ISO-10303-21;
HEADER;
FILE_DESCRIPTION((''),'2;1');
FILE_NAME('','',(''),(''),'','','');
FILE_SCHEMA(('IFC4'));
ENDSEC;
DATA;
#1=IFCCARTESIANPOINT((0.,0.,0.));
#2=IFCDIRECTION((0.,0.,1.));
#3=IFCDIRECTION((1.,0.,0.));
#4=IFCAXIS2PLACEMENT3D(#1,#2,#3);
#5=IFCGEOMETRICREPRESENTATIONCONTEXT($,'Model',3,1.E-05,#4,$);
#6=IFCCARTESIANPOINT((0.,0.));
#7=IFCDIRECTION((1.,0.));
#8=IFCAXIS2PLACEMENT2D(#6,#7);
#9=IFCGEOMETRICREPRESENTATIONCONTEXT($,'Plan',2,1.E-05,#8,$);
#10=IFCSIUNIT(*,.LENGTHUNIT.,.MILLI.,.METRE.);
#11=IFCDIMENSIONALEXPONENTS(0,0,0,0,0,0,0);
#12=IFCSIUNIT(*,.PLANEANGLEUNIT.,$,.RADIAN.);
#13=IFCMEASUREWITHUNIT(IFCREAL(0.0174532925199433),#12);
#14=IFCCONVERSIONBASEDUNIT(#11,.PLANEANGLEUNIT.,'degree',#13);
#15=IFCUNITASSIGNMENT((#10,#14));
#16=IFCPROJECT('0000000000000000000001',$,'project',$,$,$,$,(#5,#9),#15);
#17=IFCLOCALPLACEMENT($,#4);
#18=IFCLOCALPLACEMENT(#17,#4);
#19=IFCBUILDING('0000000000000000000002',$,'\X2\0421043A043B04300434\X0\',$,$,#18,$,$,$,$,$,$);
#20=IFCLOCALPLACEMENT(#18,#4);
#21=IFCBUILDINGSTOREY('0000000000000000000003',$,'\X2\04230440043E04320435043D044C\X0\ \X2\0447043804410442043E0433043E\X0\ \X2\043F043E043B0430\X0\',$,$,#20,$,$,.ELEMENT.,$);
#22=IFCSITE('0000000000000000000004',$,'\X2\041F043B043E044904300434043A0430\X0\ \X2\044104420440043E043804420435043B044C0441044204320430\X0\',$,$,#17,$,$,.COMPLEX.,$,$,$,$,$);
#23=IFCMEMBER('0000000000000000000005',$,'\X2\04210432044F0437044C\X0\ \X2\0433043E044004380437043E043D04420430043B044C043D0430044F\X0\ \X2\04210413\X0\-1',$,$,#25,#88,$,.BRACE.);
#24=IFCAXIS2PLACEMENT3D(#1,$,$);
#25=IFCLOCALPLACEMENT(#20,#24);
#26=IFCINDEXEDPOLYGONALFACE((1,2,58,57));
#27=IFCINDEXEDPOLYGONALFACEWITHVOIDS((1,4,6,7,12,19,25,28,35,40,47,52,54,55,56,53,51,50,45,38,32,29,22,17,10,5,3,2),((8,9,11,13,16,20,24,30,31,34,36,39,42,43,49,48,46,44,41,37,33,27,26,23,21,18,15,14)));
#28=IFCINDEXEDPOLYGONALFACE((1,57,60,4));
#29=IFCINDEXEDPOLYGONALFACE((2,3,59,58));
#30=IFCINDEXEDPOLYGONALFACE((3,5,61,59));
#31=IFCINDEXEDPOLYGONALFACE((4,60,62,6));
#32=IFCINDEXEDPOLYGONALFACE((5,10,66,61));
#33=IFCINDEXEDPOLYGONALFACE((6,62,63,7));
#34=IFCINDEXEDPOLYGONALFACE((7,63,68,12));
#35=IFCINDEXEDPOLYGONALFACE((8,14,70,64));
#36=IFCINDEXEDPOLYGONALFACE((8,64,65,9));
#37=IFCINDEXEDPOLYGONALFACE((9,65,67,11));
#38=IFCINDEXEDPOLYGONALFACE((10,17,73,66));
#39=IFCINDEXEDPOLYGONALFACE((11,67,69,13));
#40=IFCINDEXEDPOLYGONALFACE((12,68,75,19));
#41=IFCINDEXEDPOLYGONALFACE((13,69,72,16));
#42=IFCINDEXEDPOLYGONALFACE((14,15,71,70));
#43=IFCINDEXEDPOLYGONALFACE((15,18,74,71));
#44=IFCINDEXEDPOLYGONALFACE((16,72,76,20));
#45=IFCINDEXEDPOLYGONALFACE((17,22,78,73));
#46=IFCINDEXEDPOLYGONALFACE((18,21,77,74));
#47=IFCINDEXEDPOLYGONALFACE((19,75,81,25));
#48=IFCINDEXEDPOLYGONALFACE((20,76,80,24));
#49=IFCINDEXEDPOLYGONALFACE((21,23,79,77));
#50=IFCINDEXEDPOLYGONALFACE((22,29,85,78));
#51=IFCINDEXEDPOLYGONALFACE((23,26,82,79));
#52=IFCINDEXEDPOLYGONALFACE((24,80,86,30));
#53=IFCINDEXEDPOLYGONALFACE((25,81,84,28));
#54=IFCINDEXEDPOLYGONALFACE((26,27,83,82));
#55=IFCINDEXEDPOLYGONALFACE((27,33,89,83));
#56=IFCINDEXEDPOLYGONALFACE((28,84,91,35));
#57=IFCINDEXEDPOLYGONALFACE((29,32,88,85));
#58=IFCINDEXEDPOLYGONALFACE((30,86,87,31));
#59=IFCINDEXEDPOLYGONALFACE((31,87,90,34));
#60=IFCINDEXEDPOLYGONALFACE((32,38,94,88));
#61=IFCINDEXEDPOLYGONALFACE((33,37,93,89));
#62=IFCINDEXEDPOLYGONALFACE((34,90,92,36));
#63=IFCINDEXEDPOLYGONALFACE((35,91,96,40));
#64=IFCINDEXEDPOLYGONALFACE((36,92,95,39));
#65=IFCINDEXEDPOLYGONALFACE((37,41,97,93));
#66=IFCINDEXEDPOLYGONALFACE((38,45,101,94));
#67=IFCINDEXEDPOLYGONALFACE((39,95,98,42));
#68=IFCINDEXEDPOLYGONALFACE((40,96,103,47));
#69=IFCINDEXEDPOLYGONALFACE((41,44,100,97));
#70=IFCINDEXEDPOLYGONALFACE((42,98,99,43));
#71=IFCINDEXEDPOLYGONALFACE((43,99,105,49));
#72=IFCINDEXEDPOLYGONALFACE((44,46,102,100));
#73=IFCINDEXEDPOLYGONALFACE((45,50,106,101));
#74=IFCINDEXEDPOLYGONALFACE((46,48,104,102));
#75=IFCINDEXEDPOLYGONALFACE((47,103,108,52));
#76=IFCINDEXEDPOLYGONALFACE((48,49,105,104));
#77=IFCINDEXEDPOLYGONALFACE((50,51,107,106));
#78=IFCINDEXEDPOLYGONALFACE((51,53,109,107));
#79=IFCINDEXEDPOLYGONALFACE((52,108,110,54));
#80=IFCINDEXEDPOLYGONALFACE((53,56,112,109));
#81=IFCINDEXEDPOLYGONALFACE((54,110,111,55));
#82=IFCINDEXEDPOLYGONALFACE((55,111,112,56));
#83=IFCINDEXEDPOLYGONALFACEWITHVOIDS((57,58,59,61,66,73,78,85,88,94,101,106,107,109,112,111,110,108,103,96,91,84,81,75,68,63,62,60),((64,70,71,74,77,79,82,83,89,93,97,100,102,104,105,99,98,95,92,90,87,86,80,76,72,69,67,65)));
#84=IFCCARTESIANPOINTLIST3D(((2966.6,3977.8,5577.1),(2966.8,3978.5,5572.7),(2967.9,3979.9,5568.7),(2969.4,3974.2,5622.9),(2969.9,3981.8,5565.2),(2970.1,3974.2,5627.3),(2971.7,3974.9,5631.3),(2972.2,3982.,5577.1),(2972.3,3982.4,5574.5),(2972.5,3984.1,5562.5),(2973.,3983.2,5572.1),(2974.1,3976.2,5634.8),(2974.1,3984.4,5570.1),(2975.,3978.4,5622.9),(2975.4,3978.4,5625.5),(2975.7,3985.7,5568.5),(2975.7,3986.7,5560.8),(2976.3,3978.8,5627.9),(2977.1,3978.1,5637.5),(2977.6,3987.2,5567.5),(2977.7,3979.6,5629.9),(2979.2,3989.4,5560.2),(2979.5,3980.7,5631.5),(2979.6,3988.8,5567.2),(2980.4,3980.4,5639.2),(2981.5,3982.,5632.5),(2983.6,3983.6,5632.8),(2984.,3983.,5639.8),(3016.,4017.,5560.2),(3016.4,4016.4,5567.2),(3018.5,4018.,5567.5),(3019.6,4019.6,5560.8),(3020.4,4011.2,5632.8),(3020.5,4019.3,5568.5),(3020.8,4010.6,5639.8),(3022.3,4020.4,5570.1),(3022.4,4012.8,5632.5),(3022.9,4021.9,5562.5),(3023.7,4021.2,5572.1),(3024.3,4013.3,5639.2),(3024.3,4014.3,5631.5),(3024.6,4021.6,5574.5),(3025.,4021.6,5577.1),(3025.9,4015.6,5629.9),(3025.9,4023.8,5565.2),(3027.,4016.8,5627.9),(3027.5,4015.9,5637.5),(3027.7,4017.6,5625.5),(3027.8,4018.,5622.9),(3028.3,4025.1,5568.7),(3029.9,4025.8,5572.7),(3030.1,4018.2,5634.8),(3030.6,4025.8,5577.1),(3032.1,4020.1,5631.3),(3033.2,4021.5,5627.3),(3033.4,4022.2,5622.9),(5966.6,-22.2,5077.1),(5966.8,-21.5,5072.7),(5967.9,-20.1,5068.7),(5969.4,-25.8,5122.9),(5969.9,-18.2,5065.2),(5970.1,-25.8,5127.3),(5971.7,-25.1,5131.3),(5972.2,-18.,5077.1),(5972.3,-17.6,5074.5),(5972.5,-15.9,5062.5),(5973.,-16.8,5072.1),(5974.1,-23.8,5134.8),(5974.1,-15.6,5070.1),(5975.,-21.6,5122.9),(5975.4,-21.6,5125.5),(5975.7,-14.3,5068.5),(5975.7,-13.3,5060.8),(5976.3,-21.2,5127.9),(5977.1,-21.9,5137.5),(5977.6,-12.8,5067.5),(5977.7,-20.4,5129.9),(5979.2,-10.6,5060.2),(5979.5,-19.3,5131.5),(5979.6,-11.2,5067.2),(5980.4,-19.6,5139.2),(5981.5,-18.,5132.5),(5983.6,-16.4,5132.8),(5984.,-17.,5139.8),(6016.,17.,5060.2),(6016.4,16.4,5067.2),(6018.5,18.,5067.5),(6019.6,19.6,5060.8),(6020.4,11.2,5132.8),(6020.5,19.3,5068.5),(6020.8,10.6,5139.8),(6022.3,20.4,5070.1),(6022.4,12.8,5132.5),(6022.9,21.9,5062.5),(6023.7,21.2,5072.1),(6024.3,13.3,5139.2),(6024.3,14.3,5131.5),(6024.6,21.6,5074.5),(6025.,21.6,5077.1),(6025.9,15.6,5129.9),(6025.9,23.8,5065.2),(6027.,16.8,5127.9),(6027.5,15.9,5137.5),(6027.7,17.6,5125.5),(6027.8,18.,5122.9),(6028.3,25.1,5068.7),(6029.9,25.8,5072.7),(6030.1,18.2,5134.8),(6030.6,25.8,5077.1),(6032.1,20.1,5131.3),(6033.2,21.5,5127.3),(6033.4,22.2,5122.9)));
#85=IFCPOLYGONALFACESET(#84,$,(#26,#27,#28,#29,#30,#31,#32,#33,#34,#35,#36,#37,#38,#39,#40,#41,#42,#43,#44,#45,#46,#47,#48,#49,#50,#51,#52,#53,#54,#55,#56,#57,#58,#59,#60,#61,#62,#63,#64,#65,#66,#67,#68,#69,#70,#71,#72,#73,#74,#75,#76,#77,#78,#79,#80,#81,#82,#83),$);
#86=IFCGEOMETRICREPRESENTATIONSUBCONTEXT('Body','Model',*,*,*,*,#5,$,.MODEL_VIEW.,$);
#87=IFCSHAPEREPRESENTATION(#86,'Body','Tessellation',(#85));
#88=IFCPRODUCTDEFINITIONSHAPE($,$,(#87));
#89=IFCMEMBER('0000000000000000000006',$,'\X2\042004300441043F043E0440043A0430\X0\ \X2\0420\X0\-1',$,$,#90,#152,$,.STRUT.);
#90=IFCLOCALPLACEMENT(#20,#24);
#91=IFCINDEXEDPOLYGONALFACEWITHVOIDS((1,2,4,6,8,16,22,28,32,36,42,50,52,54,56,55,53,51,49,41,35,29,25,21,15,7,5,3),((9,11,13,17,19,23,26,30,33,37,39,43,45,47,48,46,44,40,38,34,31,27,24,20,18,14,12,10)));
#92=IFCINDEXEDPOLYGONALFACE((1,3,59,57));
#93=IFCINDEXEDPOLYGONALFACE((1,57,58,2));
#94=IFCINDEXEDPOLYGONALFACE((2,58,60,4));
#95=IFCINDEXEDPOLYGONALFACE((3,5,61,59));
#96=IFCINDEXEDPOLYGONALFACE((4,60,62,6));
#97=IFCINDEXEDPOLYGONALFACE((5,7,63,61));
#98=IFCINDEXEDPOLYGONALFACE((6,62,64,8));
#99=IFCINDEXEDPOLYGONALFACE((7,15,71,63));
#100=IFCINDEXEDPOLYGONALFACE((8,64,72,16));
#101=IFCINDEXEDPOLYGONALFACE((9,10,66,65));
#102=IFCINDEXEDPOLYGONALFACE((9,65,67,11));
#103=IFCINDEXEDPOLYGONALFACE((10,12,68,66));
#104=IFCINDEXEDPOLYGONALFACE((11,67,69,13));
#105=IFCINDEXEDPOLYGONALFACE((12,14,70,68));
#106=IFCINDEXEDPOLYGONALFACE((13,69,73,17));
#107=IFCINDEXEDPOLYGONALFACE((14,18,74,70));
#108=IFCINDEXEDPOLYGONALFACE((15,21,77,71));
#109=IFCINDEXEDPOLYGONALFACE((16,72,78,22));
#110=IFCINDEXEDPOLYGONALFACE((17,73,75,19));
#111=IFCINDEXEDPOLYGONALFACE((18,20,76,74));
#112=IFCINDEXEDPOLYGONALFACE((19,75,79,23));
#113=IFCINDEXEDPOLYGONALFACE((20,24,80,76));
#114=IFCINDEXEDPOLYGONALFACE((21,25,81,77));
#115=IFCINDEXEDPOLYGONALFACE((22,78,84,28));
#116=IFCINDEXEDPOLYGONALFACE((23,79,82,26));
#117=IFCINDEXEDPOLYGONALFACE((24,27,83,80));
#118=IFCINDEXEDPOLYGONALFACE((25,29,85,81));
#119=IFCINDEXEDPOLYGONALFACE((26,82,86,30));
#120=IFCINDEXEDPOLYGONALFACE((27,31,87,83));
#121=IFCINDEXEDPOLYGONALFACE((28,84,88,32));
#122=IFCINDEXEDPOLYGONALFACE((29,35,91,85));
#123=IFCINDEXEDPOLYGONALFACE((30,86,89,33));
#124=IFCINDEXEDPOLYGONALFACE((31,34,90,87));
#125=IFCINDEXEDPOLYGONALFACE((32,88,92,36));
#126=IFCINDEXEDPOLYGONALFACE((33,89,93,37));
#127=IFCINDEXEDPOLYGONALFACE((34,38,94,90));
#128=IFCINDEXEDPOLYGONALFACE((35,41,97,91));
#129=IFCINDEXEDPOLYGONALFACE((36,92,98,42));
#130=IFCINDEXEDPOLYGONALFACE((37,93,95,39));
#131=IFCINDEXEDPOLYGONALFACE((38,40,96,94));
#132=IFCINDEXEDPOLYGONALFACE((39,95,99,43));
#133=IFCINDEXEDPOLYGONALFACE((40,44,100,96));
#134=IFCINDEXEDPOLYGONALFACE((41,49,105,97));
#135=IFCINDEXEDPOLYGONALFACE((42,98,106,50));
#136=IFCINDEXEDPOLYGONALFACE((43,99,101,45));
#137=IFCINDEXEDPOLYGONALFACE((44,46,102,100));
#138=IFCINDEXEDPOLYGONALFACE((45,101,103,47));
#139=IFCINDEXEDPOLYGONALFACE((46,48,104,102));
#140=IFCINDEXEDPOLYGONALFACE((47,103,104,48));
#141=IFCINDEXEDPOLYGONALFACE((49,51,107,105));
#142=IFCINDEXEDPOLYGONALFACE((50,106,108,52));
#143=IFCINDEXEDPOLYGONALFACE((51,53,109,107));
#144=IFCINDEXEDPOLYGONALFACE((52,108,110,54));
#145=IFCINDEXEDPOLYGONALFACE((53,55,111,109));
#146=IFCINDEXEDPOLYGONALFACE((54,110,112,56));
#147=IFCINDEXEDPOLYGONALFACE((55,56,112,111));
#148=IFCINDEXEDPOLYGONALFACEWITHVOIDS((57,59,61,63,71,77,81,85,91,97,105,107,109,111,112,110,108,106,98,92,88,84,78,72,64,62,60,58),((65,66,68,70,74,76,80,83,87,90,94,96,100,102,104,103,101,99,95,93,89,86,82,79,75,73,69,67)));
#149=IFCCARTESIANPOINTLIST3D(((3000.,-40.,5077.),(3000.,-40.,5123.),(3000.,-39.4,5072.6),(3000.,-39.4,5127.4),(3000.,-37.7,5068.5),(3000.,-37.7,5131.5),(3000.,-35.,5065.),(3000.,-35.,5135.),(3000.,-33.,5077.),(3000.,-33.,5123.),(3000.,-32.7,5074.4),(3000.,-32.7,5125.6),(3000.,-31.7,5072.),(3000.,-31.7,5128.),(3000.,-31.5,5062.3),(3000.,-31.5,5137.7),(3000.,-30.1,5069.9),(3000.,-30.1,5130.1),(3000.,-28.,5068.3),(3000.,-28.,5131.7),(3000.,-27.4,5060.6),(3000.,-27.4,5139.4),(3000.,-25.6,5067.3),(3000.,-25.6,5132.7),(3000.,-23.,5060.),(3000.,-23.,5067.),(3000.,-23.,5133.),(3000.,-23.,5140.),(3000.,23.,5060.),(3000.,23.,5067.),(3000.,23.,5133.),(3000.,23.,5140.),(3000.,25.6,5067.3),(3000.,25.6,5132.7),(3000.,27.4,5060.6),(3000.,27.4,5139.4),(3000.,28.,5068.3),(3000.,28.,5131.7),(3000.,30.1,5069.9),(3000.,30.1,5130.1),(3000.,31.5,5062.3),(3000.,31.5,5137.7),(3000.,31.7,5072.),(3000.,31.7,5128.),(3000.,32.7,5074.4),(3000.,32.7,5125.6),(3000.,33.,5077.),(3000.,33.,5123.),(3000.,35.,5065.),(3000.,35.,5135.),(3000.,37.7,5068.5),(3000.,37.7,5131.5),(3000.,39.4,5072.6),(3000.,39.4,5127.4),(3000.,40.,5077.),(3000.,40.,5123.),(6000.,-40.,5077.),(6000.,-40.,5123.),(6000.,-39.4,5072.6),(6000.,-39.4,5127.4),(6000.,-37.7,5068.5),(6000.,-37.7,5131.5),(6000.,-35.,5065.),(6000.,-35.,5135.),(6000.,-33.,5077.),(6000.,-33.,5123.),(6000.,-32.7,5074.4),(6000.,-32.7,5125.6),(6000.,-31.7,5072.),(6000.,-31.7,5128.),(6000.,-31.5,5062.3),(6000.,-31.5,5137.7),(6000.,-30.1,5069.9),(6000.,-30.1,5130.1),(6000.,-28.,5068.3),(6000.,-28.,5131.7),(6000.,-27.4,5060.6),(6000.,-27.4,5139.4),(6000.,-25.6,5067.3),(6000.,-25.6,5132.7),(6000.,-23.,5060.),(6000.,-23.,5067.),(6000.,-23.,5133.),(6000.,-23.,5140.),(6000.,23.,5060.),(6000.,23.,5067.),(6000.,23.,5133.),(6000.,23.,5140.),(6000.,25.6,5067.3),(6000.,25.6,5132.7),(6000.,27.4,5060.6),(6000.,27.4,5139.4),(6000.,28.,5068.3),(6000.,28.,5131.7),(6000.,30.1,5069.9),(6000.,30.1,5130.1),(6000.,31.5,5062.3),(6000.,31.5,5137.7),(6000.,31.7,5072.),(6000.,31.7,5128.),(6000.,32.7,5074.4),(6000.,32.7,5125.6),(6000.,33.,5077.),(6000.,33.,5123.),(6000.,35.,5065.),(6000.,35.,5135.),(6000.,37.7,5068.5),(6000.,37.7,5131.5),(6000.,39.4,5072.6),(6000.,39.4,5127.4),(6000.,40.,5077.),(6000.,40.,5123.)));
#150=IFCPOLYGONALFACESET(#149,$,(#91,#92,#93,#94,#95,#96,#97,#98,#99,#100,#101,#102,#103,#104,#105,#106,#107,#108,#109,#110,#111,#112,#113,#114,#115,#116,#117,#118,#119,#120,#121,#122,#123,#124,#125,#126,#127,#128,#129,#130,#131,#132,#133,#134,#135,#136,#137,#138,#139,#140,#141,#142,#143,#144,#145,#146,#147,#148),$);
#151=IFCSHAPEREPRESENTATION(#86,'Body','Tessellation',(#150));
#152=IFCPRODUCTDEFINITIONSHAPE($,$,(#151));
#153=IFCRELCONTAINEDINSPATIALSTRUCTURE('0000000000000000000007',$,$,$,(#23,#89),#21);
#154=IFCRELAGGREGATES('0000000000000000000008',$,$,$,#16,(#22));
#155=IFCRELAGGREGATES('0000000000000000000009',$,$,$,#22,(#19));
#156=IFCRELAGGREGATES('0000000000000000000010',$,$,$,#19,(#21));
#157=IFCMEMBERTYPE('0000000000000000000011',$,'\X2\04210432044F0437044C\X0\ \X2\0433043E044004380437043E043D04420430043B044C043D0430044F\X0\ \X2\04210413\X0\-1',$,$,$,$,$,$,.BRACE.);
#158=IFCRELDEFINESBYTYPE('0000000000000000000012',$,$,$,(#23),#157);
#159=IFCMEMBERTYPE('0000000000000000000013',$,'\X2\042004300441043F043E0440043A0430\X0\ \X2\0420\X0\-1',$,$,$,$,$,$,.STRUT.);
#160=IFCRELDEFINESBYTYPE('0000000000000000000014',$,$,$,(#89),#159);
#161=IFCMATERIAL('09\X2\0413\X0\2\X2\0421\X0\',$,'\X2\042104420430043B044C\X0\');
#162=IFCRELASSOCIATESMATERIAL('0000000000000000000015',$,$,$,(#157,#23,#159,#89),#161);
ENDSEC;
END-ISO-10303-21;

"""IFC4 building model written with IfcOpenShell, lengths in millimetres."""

from ifc_helpers import new_model, entity, si_unit, converted_unit, frame, origin_with_axes, origin_2d_with_axis, place, context, subcontext, project, spatial, hollow_rectangle, extrude, material, material_profile, profile_set, profile_usage, type_object, element, save


model = new_model("IFC4")

# Units and contexts
model_context = context("Model", 3, precision=1e-05, world=origin_with_axes())
plan_context = context("Plan", 2, precision=1e-05, world=origin_2d_with_axis())
body_context = subcontext(model_context, "Body", "Model", "MODEL_VIEW")
ifc_project = project(units=[si_unit("LENGTHUNIT", "METRE", prefix="MILLI"), converted_unit("PLANEANGLEUNIT", "degree", entity("IfcReal", 0.0174532925199433), si_unit("PLANEANGLEUNIT", "RADIAN"), dimensions=[0, 0, 0, 0, 0, 0, 0])], contexts=[model_context, plan_context])

# Site, building, storey
site_placement = place(None, origin_with_axes())
site = spatial("IfcSite", under=ifc_project, at=site_placement, Name="Площадка строительства", CompositionType="COMPLEX")
building_placement = place(site_placement, origin_with_axes())
building = spatial("IfcBuilding", under=site, at=building_placement, Name="Склад")
storey_placement = place(building_placement, origin_with_axes())
storey = spatial("IfcBuildingStorey", under=building, at=storey_placement, Name="Уровень чистого пола", CompositionType="ELEMENT")

# Members
ifc_material_1 = material(Name="09Г2С", Category="Сталь")
ifc_material_profile_1 = material_profile(ifc_material_1, hollow_rectangle(XDim=80.0, YDim=80.0, WallThickness=7.0, InnerFilletRadius=10.0, OuterFilletRadius=17.0))
ifc_profile_set_1 = profile_set([ifc_material_profile_1], Name="PK80x7_09G2S")
ifc_profile_usage_1 = profile_usage(ifc_profile_set_1, cardinal=5)
member_type_1 = type_object("IfcMemberType", Name="Связь горизонтальная СГ-1", PredefinedType="BRACE", material=ifc_profile_set_1)
member_1_placement = place(storey_placement, frame((6000.0, 0.0, 5100.0), z_axis=(-0.597022, 0.79603, 0.099504), x_axis=(-0.8, -0.6, 0.0)))
element("IfcMember", 1, at=member_1_placement, inside=storey, type_object=member_type_1, material=ifc_profile_usage_1, Name="Связь горизонтальная СГ-1", PredefinedType="BRACE", context=body_context, shape_type="SweptSolid", body=[
    extrude(hollow_rectangle(XDim=80.0, YDim=80.0, WallThickness=7.0, InnerFilletRadius=10.0, OuterFilletRadius=17.0), origin_with_axes(), (0.0, 0.0, 1.0), 5024.9),
])
ifc_material_profile_2 = material_profile(ifc_material_1, hollow_rectangle(XDim=80.0, YDim=80.0, WallThickness=7.0, InnerFilletRadius=10.0, OuterFilletRadius=17.0))
ifc_profile_set_2 = profile_set([ifc_material_profile_2], Name="PK80x7_09G2S")
ifc_profile_usage_2 = profile_usage(ifc_profile_set_2, cardinal=5)
member_type_2 = type_object("IfcMemberType", Name="Распорка Р-1", PredefinedType="STRUT", material=ifc_profile_set_2)
member_2_placement = place(storey_placement, frame((3000.0, 0.0, 5100.0), z_axis=(1.0, 0.0, 0.0), x_axis=(0.0, 1.0, 0.0)))
element("IfcMember", 2, at=member_2_placement, inside=storey, type_object=member_type_2, material=ifc_profile_usage_2, Name="Распорка Р-1", PredefinedType="STRUT", context=body_context, shape_type="SweptSolid", body=[
    extrude(hollow_rectangle(XDim=80.0, YDim=80.0, WallThickness=7.0, InnerFilletRadius=10.0, OuterFilletRadius=17.0), origin_with_axes(), (0.0, 0.0, 1.0), 3000.0),
])

save(model, "model.ifc")
